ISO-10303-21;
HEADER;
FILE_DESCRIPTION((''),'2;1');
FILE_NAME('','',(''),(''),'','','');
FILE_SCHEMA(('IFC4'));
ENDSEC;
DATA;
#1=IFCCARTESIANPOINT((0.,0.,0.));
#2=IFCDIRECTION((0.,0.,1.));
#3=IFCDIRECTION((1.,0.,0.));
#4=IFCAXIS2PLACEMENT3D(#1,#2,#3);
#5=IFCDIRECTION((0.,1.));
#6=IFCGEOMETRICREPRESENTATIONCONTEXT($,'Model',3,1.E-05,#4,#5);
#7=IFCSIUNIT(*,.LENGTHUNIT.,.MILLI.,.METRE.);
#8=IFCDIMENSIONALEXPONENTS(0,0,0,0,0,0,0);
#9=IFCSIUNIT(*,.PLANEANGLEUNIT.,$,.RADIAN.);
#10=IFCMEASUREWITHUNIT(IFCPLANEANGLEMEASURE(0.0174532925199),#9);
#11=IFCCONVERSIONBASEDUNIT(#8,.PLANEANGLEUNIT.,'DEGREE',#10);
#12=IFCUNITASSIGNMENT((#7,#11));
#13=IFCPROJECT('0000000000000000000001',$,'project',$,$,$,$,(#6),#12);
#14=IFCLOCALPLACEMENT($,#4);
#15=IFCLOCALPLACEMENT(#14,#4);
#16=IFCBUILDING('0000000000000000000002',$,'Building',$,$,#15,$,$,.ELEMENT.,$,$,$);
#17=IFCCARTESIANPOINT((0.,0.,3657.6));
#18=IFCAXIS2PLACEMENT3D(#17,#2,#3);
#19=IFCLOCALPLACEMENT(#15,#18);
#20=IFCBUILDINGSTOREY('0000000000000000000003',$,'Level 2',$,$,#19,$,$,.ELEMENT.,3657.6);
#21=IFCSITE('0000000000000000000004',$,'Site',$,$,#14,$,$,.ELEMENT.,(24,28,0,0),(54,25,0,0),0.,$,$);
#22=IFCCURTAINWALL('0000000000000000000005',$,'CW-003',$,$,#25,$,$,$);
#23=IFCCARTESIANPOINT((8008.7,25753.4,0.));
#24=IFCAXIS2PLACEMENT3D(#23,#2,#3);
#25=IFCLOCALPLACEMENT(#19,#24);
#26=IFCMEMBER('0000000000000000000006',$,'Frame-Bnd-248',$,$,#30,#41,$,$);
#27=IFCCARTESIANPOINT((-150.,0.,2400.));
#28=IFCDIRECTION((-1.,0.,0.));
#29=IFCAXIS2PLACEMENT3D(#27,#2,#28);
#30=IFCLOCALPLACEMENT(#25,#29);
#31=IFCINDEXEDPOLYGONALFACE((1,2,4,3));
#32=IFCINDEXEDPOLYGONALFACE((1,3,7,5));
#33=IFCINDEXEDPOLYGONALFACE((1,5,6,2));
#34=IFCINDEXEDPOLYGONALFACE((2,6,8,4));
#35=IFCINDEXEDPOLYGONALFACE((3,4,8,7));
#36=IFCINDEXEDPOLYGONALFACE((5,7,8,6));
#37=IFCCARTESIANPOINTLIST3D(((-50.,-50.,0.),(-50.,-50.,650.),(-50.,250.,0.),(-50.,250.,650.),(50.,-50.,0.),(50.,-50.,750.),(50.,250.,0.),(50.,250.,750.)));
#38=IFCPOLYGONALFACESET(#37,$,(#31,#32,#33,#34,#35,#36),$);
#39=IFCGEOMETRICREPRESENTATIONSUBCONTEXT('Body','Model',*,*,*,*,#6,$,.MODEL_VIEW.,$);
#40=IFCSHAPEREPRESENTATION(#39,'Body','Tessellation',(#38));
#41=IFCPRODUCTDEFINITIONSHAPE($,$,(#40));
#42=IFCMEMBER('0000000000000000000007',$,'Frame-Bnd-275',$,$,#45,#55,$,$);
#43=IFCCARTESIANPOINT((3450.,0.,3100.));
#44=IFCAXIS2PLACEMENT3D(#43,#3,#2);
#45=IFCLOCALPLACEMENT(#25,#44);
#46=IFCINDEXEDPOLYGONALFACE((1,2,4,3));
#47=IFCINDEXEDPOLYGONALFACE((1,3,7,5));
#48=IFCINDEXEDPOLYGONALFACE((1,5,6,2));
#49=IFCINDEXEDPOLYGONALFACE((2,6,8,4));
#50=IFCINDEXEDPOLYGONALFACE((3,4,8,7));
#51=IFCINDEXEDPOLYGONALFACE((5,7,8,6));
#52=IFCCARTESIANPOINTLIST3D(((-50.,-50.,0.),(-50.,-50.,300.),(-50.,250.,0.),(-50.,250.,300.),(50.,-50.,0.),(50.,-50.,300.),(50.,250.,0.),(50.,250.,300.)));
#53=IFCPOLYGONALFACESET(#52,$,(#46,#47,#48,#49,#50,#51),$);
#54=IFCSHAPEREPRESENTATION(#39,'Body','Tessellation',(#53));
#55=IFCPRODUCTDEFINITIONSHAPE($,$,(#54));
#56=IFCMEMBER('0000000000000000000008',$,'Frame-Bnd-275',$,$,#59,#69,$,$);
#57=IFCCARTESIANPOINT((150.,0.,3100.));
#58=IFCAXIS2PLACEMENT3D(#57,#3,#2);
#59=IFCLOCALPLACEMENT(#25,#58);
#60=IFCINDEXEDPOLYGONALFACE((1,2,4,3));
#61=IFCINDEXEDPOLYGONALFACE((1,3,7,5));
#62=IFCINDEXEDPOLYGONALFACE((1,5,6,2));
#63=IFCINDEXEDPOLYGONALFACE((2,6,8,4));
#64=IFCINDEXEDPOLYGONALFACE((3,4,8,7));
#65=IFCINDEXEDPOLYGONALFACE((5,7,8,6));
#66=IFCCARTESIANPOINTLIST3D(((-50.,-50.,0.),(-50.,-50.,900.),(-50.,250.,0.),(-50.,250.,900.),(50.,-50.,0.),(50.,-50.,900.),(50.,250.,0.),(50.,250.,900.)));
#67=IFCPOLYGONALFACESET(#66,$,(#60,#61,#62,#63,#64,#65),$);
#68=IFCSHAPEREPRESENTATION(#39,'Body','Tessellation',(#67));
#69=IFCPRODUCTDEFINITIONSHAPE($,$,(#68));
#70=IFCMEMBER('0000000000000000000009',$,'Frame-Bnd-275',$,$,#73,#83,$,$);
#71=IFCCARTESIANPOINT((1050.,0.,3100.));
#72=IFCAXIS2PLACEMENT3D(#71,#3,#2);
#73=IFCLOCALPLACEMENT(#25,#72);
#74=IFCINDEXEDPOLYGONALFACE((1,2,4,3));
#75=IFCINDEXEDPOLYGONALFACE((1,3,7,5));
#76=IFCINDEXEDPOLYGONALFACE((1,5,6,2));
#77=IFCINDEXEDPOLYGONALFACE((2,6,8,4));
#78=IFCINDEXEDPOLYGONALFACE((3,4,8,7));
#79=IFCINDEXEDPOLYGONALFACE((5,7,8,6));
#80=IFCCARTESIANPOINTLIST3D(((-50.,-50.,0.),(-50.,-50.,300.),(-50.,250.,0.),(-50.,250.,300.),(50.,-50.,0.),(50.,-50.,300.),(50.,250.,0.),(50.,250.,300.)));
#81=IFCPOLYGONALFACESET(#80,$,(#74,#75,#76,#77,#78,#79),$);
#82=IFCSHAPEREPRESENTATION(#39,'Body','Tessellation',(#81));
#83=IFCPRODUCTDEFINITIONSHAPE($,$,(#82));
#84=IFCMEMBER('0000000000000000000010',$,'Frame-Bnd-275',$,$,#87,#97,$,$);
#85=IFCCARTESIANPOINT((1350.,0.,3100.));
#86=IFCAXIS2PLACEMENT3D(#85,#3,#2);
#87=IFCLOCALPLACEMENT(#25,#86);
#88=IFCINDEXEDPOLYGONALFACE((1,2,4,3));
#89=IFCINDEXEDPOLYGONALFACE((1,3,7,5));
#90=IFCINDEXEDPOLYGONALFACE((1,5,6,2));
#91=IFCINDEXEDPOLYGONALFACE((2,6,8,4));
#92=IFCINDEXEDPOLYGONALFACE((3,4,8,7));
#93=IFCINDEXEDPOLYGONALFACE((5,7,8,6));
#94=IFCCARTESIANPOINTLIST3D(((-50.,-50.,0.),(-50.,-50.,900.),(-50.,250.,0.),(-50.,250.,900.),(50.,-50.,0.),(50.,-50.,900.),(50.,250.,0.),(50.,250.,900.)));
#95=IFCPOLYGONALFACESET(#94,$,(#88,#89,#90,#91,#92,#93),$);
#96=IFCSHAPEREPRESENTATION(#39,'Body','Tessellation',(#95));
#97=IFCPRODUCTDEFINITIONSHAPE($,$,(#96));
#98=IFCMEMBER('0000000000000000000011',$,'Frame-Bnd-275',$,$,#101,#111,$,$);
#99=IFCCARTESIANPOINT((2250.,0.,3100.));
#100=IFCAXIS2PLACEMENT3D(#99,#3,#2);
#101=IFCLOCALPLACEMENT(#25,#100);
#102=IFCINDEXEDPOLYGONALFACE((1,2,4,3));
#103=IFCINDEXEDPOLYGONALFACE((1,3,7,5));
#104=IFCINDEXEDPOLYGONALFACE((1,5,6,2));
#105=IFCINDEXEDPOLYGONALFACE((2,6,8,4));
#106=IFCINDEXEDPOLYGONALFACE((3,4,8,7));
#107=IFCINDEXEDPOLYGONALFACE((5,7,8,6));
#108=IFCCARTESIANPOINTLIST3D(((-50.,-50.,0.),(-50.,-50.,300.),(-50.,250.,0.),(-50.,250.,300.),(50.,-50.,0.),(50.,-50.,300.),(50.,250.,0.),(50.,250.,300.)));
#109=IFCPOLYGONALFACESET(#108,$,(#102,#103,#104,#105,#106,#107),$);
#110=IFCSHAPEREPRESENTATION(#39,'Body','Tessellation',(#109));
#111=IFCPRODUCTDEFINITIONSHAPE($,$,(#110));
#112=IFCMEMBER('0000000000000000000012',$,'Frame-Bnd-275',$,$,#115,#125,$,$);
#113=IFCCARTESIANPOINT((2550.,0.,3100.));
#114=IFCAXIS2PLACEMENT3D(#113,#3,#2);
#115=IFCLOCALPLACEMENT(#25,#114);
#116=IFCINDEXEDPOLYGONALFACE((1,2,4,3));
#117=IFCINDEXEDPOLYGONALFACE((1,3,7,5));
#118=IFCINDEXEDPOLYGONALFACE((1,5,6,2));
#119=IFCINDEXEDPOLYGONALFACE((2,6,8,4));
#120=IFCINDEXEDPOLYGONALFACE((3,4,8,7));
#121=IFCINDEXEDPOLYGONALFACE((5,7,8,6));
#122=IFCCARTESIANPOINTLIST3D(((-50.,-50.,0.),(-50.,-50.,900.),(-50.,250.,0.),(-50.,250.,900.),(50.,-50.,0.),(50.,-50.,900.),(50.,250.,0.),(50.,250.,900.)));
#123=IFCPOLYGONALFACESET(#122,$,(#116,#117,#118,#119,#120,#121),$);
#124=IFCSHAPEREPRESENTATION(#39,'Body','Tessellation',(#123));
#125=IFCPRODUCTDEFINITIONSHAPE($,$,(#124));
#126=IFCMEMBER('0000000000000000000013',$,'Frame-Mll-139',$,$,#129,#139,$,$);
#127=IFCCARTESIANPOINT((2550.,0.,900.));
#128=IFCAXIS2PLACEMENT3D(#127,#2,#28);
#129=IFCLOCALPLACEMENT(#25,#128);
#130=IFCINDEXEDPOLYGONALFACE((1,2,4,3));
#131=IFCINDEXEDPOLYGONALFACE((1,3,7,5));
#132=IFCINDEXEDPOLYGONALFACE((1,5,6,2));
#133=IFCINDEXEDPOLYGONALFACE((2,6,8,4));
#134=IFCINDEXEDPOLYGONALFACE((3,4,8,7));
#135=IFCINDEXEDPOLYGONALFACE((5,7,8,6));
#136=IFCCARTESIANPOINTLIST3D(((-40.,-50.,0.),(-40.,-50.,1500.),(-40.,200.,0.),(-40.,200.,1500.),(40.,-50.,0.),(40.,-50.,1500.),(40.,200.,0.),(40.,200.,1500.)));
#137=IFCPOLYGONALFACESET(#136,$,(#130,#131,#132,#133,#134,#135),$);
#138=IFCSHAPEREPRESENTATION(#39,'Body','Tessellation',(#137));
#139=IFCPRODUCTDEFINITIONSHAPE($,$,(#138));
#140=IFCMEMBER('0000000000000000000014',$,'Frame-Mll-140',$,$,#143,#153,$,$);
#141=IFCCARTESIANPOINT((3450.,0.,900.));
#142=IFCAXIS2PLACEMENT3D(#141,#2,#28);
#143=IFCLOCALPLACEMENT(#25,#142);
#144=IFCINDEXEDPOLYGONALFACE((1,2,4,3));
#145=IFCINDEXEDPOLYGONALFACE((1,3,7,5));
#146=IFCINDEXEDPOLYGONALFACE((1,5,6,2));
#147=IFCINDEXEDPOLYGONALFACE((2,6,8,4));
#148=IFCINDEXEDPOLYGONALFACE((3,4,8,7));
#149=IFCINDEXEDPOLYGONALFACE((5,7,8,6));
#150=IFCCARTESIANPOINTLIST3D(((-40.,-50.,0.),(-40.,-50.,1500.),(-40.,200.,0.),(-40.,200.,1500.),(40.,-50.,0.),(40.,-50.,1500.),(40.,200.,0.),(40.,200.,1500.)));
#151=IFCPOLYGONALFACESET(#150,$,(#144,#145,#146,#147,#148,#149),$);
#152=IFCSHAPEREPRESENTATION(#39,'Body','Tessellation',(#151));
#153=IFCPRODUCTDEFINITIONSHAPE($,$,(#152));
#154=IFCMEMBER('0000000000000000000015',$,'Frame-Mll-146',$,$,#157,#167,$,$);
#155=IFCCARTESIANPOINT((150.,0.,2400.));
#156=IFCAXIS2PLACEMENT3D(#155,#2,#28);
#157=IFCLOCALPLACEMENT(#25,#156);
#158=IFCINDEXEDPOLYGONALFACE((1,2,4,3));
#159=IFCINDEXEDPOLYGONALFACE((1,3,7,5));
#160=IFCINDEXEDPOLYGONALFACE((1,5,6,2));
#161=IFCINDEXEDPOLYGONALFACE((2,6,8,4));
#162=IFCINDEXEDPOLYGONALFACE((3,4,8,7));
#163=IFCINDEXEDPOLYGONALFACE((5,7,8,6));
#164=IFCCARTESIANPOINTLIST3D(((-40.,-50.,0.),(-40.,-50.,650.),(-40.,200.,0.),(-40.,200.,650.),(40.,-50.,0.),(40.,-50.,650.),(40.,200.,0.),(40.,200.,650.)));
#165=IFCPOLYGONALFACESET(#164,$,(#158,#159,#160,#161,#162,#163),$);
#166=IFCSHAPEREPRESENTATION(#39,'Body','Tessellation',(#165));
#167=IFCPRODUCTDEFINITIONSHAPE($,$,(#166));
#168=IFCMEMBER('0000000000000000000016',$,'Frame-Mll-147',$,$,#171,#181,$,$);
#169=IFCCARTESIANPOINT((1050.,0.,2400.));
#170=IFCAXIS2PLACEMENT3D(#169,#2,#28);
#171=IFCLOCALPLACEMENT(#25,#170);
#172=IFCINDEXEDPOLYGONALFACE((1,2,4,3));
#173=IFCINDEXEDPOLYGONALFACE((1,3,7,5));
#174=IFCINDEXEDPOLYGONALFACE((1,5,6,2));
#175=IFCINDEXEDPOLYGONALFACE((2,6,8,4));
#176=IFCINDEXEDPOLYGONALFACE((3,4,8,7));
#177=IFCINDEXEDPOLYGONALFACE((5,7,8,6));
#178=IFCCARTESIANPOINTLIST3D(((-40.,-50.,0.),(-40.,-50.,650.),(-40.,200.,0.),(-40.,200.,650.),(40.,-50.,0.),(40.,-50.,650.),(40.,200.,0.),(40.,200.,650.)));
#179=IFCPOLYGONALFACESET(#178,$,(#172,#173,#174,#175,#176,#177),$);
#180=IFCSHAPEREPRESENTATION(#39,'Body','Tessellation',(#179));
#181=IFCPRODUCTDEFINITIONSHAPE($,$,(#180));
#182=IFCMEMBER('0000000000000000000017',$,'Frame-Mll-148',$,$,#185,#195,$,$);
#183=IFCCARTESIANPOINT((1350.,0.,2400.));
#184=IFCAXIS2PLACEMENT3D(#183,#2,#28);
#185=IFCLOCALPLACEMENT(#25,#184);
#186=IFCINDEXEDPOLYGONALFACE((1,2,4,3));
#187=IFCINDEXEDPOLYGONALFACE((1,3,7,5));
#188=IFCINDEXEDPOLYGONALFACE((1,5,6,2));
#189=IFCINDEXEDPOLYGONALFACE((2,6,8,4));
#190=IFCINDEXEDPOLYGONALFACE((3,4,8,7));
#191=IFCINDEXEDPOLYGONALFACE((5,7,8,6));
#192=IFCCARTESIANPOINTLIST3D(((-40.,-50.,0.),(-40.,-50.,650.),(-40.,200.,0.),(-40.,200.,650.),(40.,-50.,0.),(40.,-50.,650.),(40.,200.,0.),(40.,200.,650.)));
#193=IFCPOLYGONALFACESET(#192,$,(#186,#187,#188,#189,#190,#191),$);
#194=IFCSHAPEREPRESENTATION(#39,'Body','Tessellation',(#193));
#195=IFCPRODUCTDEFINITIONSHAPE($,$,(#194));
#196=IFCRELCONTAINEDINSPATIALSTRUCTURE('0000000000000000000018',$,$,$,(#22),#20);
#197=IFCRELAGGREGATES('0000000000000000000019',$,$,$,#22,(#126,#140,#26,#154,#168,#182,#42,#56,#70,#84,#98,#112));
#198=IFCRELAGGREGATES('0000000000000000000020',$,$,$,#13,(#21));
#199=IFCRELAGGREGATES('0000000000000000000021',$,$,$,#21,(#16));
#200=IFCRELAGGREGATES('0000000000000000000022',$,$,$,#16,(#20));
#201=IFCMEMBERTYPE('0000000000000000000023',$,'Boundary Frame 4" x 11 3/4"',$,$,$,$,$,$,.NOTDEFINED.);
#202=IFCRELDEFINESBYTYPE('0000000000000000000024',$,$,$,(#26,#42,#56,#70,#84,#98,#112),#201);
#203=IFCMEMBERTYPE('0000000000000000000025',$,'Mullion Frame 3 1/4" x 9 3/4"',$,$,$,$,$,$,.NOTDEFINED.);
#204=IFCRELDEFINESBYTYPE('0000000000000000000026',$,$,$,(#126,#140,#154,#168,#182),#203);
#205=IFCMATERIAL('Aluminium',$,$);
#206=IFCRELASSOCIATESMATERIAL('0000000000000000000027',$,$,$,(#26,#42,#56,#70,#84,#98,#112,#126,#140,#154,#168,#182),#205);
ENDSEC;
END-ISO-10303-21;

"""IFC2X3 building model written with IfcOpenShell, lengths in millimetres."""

from ifc_helpers import new_model, entity, si_unit, converted_unit, direction, frame, origin_with_axes, place, context, subcontext, project, spatial, polyline, outline, extrude, clip, halfspace, material, type_object, element, aggregate, save


model = new_model("IFC2X3")

# Units and contexts
model_context = context("Model", 3, precision=1e-05, world=origin_with_axes(), true_north=direction((0.0, 1.0)))
body_context = subcontext(model_context, "Body", "Model", "MODEL_VIEW")
ifc_project = project(units=[si_unit("LENGTHUNIT", "METRE", prefix="MILLI"), converted_unit("PLANEANGLEUNIT", "DEGREE", entity("IfcPlaneAngleMeasure", 0.0174532925199), si_unit("PLANEANGLEUNIT", "RADIAN"), dimensions=[0, 0, 0, 0, 0, 0, 0])], contexts=[model_context])

# Site, building, storey
site_placement = place(None, origin_with_axes())
site = spatial("IfcSite", under=ifc_project, at=site_placement, Name="Site", CompositionType="ELEMENT", RefLatitude=(24, 28, 0, 0), RefLongitude=(54, 25, 0, 0), RefElevation=0.0)
building_placement = place(site_placement, origin_with_axes())
building = spatial("IfcBuilding", under=site, at=building_placement, Name="Building", CompositionType="ELEMENT")
storey_placement = place(building_placement, frame((0.0, 0.0, 3657.6), z_axis=(0.0, 0.0, 1.0), x_axis=(1.0, 0.0, 0.0)))
storey = spatial("IfcBuildingStorey", under=building, at=storey_placement, Name="Level 2", CompositionType="ELEMENT", Elevation=3657.6)

# Curtain wall, members
curtain_wall_placement = place(storey_placement, frame((8008.7, 25753.4, 0.0), z_axis=(0.0, 0.0, 1.0), x_axis=(1.0, 0.0, 0.0)))
curtain_wall = element("IfcCurtainWall", 1, at=curtain_wall_placement, inside=storey, Name="CW-003")
ifc_material_1 = material(Name="Aluminium")
member_type_1 = type_object("IfcMemberType", Name="Boundary Frame 4\" x 11 3/4\"", PredefinedType="NOTDEFINED")
member_1_placement = place(curtain_wall_placement, frame((-150.0, 0.0, 2400.0), z_axis=(0.0, 0.0, 1.0), x_axis=(-1.0, 0.0, 0.0)))
member_1 = element("IfcMember", 2, at=member_1_placement, type_object=member_type_1, material=ifc_material_1, Name="Frame-Bnd-248", context=body_context, shape_type="Clipping", body=[
    clip(extrude(outline(polyline([(-50.0, -250.0), (50.0, -250.0), (50.0, 50.0), (-50.0, 50.0), (-50.0, -250.0)])), frame((0.0, 0.0, 0.0), z_axis=(0.0, 0.0, 1.0), x_axis=(-1.0, 0.0, 0.0)), (0.0, 0.0, 1.0), 750.0), halfspace(frame((-350.0, 0.0, 350.0), z_axis=(0.707107, 0.0, -0.707107), x_axis=(0.0, 1.0, 0.0)), True)),
])
member_2_placement = place(curtain_wall_placement, frame((3450.0, 0.0, 3100.0), z_axis=(1.0, 0.0, 0.0), x_axis=(0.0, 0.0, 1.0)))
member_2 = element("IfcMember", 3, at=member_2_placement, type_object=member_type_1, material=ifc_material_1, Name="Frame-Bnd-275", context=body_context, shape_type="SweptSolid", body=[
    extrude(outline(polyline([(250.0, -50.0), (250.0, 50.0), (-50.0, 50.0), (-50.0, -50.0), (250.0, -50.0)])), frame((0.0, 0.0, 0.0), z_axis=(0.0, 0.0, 1.0), x_axis=(0.0, 1.0, 0.0)), (0.0, 0.0, 1.0), 300.0),
])
member_3_placement = place(curtain_wall_placement, frame((150.0, 0.0, 3100.0), z_axis=(1.0, 0.0, 0.0), x_axis=(0.0, 0.0, 1.0)))
member_3 = element("IfcMember", 4, at=member_3_placement, type_object=member_type_1, material=ifc_material_1, Name="Frame-Bnd-275", context=body_context, shape_type="SweptSolid", body=[
    extrude(outline(polyline([(250.0, -50.0), (250.0, 50.0), (-50.0, 50.0), (-50.0, -50.0), (250.0, -50.0)])), frame((0.0, 0.0, 0.0), z_axis=(0.0, 0.0, 1.0), x_axis=(0.0, 1.0, 0.0)), (0.0, 0.0, 1.0), 900.0),
])
member_4_placement = place(curtain_wall_placement, frame((1050.0, 0.0, 3100.0), z_axis=(1.0, 0.0, 0.0), x_axis=(0.0, 0.0, 1.0)))
member_4 = element("IfcMember", 5, at=member_4_placement, type_object=member_type_1, material=ifc_material_1, Name="Frame-Bnd-275", context=body_context, shape_type="SweptSolid", body=[
    extrude(outline(polyline([(250.0, -50.0), (250.0, 50.0), (-50.0, 50.0), (-50.0, -50.0), (250.0, -50.0)])), frame((0.0, 0.0, 0.0), z_axis=(0.0, 0.0, 1.0), x_axis=(0.0, 1.0, 0.0)), (0.0, 0.0, 1.0), 300.0),
])
member_5_placement = place(curtain_wall_placement, frame((1350.0, 0.0, 3100.0), z_axis=(1.0, 0.0, 0.0), x_axis=(0.0, 0.0, 1.0)))
member_5 = element("IfcMember", 6, at=member_5_placement, type_object=member_type_1, material=ifc_material_1, Name="Frame-Bnd-275", context=body_context, shape_type="SweptSolid", body=[
    extrude(outline(polyline([(250.0, -50.0), (250.0, 50.0), (-50.0, 50.0), (-50.0, -50.0), (250.0, -50.0)])), frame((0.0, 0.0, 0.0), z_axis=(0.0, 0.0, 1.0), x_axis=(0.0, 1.0, 0.0)), (0.0, 0.0, 1.0), 900.0),
])
member_6_placement = place(curtain_wall_placement, frame((2250.0, 0.0, 3100.0), z_axis=(1.0, 0.0, 0.0), x_axis=(0.0, 0.0, 1.0)))
member_6 = element("IfcMember", 7, at=member_6_placement, type_object=member_type_1, material=ifc_material_1, Name="Frame-Bnd-275", context=body_context, shape_type="SweptSolid", body=[
    extrude(outline(polyline([(250.0, -50.0), (250.0, 50.0), (-50.0, 50.0), (-50.0, -50.0), (250.0, -50.0)])), frame((0.0, 0.0, 0.0), z_axis=(0.0, 0.0, 1.0), x_axis=(0.0, 1.0, 0.0)), (0.0, 0.0, 1.0), 300.0),
])
member_7_placement = place(curtain_wall_placement, frame((2550.0, 0.0, 3100.0), z_axis=(1.0, 0.0, 0.0), x_axis=(0.0, 0.0, 1.0)))
member_7 = element("IfcMember", 8, at=member_7_placement, type_object=member_type_1, material=ifc_material_1, Name="Frame-Bnd-275", context=body_context, shape_type="SweptSolid", body=[
    extrude(outline(polyline([(250.0, -50.0), (250.0, 50.0), (-50.0, 50.0), (-50.0, -50.0), (250.0, -50.0)])), frame((0.0, 0.0, 0.0), z_axis=(0.0, 0.0, 1.0), x_axis=(0.0, 1.0, 0.0)), (0.0, 0.0, 1.0), 900.0),
])
member_type_2 = type_object("IfcMemberType", Name="Mullion Frame 3 1/4\" x 9 3/4\"", PredefinedType="NOTDEFINED")
member_8_placement = place(curtain_wall_placement, frame((2550.0, 0.0, 900.0), z_axis=(0.0, 0.0, 1.0), x_axis=(-1.0, 0.0, 0.0)))
member_8 = element("IfcMember", 9, at=member_8_placement, type_object=member_type_2, material=ifc_material_1, Name="Frame-Mll-139", context=body_context, shape_type="SweptSolid", body=[
    extrude(outline(polyline([(-40.0, -200.0), (40.0, -200.0), (40.0, 50.0), (-40.0, 50.0), (-40.0, -200.0)])), frame((0.0, 0.0, 0.0), z_axis=(0.0, 0.0, 1.0), x_axis=(-1.0, 0.0, 0.0)), (0.0, 0.0, 1.0), 1500.0),
])
member_9_placement = place(curtain_wall_placement, frame((3450.0, 0.0, 900.0), z_axis=(0.0, 0.0, 1.0), x_axis=(-1.0, 0.0, 0.0)))
member_9 = element("IfcMember", 10, at=member_9_placement, type_object=member_type_2, material=ifc_material_1, Name="Frame-Mll-140", context=body_context, shape_type="SweptSolid", body=[
    extrude(outline(polyline([(-40.0, -200.0), (40.0, -200.0), (40.0, 50.0), (-40.0, 50.0), (-40.0, -200.0)])), frame((0.0, 0.0, 0.0), z_axis=(0.0, 0.0, 1.0), x_axis=(-1.0, 0.0, 0.0)), (0.0, 0.0, 1.0), 1500.0),
])
member_10_placement = place(curtain_wall_placement, frame((150.0, 0.0, 2400.0), z_axis=(0.0, 0.0, 1.0), x_axis=(-1.0, 0.0, 0.0)))
member_10 = element("IfcMember", 11, at=member_10_placement, type_object=member_type_2, material=ifc_material_1, Name="Frame-Mll-146", context=body_context, shape_type="SweptSolid", body=[
    extrude(outline(polyline([(-40.0, -200.0), (40.0, -200.0), (40.0, 50.0), (-40.0, 50.0), (-40.0, -200.0)])), frame((0.0, 0.0, 0.0), z_axis=(0.0, 0.0, 1.0), x_axis=(-1.0, 0.0, 0.0)), (0.0, 0.0, 1.0), 650.0),
])
member_11_placement = place(curtain_wall_placement, frame((1050.0, 0.0, 2400.0), z_axis=(0.0, 0.0, 1.0), x_axis=(-1.0, 0.0, 0.0)))
member_11 = element("IfcMember", 12, at=member_11_placement, type_object=member_type_2, material=ifc_material_1, Name="Frame-Mll-147", context=body_context, shape_type="SweptSolid", body=[
    extrude(outline(polyline([(-40.0, -200.0), (40.0, -200.0), (40.0, 50.0), (-40.0, 50.0), (-40.0, -200.0)])), frame((0.0, 0.0, 0.0), z_axis=(0.0, 0.0, 1.0), x_axis=(-1.0, 0.0, 0.0)), (0.0, 0.0, 1.0), 650.0),
])
member_12_placement = place(curtain_wall_placement, frame((1350.0, 0.0, 2400.0), z_axis=(0.0, 0.0, 1.0), x_axis=(-1.0, 0.0, 0.0)))
member_12 = element("IfcMember", 13, at=member_12_placement, type_object=member_type_2, material=ifc_material_1, Name="Frame-Mll-148", context=body_context, shape_type="SweptSolid", body=[
    extrude(outline(polyline([(-40.0, -200.0), (40.0, -200.0), (40.0, 50.0), (-40.0, 50.0), (-40.0, -200.0)])), frame((0.0, 0.0, 0.0), z_axis=(0.0, 0.0, 1.0), x_axis=(-1.0, 0.0, 0.0)), (0.0, 0.0, 1.0), 650.0),
])
aggregate(curtain_wall, [member_8, member_9, member_1, member_10, member_11, member_12, member_2, member_3, member_4, member_5, member_6, member_7])

save(model, "model.ifc")
